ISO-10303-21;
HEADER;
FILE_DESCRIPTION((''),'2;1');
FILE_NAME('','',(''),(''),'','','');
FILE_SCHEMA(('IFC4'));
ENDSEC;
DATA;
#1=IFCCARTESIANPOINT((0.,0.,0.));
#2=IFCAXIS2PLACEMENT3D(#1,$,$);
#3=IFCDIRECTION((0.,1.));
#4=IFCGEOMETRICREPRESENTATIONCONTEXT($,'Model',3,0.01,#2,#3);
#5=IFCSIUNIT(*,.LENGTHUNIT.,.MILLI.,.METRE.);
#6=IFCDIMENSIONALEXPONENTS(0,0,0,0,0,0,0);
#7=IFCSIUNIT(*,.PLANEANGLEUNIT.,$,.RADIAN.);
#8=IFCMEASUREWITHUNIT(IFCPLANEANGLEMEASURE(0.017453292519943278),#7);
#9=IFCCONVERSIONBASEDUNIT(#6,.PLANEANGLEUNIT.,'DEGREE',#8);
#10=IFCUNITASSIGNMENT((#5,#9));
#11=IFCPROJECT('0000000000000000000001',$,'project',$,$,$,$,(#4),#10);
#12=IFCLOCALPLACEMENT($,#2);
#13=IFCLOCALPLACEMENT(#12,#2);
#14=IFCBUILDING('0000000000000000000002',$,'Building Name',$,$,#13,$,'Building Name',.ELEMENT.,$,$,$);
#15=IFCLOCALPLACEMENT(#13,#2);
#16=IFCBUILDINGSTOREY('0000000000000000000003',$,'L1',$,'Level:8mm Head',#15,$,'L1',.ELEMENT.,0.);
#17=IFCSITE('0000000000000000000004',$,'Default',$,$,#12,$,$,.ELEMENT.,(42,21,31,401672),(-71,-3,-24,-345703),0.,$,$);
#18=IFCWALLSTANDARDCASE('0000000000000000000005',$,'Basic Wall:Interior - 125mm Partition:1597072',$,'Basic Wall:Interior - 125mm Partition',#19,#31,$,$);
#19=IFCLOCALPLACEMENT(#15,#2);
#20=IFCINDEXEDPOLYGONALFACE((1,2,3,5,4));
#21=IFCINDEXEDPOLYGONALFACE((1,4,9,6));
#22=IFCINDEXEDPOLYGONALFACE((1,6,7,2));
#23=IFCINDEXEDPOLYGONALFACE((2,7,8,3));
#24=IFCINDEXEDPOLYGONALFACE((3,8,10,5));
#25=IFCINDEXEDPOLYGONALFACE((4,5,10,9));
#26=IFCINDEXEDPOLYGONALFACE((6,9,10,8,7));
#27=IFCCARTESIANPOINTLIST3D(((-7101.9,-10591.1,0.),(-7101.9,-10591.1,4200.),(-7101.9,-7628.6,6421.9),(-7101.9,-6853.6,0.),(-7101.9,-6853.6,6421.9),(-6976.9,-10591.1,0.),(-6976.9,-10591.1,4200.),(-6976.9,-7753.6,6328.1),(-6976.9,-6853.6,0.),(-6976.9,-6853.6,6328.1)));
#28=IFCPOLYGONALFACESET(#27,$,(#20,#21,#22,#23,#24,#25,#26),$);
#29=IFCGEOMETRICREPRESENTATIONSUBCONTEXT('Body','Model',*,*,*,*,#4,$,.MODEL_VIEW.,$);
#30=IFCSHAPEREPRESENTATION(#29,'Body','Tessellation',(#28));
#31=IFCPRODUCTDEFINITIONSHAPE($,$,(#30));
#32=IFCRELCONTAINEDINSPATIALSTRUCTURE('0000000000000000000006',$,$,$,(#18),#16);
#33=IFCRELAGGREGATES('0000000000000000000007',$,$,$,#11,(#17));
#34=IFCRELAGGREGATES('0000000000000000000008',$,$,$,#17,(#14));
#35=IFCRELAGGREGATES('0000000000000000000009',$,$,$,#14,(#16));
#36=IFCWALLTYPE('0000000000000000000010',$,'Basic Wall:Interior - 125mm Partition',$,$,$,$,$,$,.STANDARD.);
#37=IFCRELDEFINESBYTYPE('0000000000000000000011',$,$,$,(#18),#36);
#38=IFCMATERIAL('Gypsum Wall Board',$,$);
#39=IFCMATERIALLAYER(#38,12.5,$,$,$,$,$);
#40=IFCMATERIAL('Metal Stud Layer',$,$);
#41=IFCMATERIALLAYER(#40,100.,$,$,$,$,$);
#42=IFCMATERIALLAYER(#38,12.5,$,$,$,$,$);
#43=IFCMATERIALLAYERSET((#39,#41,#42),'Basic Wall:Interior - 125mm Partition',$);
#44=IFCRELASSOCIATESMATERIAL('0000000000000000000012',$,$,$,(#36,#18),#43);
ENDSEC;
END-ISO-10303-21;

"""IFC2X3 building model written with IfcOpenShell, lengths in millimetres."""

from ifc_helpers import new_model, entity, si_unit, converted_unit, direction, frame, frame_2d, origin, place, context, subcontext, project, spatial, polyline, rectangle, extrude, clip, bounded_halfspace, material, layer, layer_set, layer_usage, type_object, element, save


model = new_model("IFC2X3")

# Units and contexts
model_context = context("Model", 3, precision=0.01, world=origin(), true_north=direction((0.0, 1.0)))
body_context = subcontext(model_context, "Body", "Model", "MODEL_VIEW")
ifc_project = project(units=[si_unit("LENGTHUNIT", "METRE", prefix="MILLI"), converted_unit("PLANEANGLEUNIT", "DEGREE", entity("IfcPlaneAngleMeasure", 0.017453292519943278), si_unit("PLANEANGLEUNIT", "RADIAN"), dimensions=[0, 0, 0, 0, 0, 0, 0])], contexts=[model_context])

# Site, building, storey
site_placement = place(None, origin())
site = spatial("IfcSite", under=ifc_project, at=site_placement, Name="Default", CompositionType="ELEMENT", RefLatitude=(42, 21, 31, 401672), RefLongitude=(-71, -3, -24, -345703), RefElevation=0.0)
building_placement = place(site_placement, origin())
building = spatial("IfcBuilding", under=site, at=building_placement, Name="Building Name", LongName="Building Name", CompositionType="ELEMENT")
storey_placement = place(building_placement, origin())
storey = spatial("IfcBuildingStorey", under=building, at=storey_placement, Name="L1", ObjectType="Level:8mm Head", LongName="L1", CompositionType="ELEMENT", Elevation=0.0)

# Wall
ifc_material_1 = material(Name="Gypsum Wall Board")
ifc_layer_1 = layer(ifc_material_1, 12.5)
ifc_material_2 = material(Name="Metal Stud Layer")
ifc_layer_2 = layer(ifc_material_2, 100.0)
ifc_layer_3 = layer(ifc_material_1, 12.5)
ifc_layer_set_1 = layer_set([ifc_layer_1, ifc_layer_2, ifc_layer_3], Name="Basic Wall:Interior - 125mm Partition")
ifc_layer_usage_1 = layer_usage(ifc_layer_set_1, "AXIS2", "NEGATIVE", 62.5)
wall_type_1 = type_object("IfcWallType", Name="Basic Wall:Interior - 125mm Partition", PredefinedType="STANDARD", material=ifc_layer_set_1)
wall_1_placement = place(storey_placement, frame((-7039.4, -6853.6, 0.0), z_axis=(0.0, 0.0, 1.0), x_axis=(0.0, -1.0, 0.0)))
element("IfcWallStandardCase", 1, at=wall_1_placement, inside=storey, type_object=wall_type_1, material=ifc_layer_usage_1, Name="Basic Wall:Interior - 125mm Partition:1597072", ObjectType="Basic Wall:Interior - 125mm Partition", context=body_context, shape_type="Clipping", body=[
    clip(clip(extrude(rectangle(XDim=3737.5, YDim=125.0, at=frame_2d((1868.8, 0.0), x_axis=(-1.0, 0.0))), origin(), (0.0, 0.0, 1.0), 6421.9), bounded_halfspace(frame((775.0, -62.5, 6421.9), z_axis=(0.6, 0.0, 0.8), x_axis=(0.0, 1.0, 0.0)), False, frame((775.0, -62.5, 6421.9)), polyline([(0.0, 0.0), (2962.5, 0.0), (2962.5, 125.0), (125.0, 125.0), (0.0, 0.0)]))), bounded_halfspace(frame((0.0, -62.5, 6421.9), z_axis=(0.0, 0.6, 0.8), x_axis=(-1.0, 0.0, 0.0)), False, frame((0.0, -62.5, 6421.9)), polyline([(0.0, 0.0), (775.0, 0.0), (900.0, 125.0), (0.0, 125.0), (0.0, 0.0)]))),
])

save(model, "model.ifc")
